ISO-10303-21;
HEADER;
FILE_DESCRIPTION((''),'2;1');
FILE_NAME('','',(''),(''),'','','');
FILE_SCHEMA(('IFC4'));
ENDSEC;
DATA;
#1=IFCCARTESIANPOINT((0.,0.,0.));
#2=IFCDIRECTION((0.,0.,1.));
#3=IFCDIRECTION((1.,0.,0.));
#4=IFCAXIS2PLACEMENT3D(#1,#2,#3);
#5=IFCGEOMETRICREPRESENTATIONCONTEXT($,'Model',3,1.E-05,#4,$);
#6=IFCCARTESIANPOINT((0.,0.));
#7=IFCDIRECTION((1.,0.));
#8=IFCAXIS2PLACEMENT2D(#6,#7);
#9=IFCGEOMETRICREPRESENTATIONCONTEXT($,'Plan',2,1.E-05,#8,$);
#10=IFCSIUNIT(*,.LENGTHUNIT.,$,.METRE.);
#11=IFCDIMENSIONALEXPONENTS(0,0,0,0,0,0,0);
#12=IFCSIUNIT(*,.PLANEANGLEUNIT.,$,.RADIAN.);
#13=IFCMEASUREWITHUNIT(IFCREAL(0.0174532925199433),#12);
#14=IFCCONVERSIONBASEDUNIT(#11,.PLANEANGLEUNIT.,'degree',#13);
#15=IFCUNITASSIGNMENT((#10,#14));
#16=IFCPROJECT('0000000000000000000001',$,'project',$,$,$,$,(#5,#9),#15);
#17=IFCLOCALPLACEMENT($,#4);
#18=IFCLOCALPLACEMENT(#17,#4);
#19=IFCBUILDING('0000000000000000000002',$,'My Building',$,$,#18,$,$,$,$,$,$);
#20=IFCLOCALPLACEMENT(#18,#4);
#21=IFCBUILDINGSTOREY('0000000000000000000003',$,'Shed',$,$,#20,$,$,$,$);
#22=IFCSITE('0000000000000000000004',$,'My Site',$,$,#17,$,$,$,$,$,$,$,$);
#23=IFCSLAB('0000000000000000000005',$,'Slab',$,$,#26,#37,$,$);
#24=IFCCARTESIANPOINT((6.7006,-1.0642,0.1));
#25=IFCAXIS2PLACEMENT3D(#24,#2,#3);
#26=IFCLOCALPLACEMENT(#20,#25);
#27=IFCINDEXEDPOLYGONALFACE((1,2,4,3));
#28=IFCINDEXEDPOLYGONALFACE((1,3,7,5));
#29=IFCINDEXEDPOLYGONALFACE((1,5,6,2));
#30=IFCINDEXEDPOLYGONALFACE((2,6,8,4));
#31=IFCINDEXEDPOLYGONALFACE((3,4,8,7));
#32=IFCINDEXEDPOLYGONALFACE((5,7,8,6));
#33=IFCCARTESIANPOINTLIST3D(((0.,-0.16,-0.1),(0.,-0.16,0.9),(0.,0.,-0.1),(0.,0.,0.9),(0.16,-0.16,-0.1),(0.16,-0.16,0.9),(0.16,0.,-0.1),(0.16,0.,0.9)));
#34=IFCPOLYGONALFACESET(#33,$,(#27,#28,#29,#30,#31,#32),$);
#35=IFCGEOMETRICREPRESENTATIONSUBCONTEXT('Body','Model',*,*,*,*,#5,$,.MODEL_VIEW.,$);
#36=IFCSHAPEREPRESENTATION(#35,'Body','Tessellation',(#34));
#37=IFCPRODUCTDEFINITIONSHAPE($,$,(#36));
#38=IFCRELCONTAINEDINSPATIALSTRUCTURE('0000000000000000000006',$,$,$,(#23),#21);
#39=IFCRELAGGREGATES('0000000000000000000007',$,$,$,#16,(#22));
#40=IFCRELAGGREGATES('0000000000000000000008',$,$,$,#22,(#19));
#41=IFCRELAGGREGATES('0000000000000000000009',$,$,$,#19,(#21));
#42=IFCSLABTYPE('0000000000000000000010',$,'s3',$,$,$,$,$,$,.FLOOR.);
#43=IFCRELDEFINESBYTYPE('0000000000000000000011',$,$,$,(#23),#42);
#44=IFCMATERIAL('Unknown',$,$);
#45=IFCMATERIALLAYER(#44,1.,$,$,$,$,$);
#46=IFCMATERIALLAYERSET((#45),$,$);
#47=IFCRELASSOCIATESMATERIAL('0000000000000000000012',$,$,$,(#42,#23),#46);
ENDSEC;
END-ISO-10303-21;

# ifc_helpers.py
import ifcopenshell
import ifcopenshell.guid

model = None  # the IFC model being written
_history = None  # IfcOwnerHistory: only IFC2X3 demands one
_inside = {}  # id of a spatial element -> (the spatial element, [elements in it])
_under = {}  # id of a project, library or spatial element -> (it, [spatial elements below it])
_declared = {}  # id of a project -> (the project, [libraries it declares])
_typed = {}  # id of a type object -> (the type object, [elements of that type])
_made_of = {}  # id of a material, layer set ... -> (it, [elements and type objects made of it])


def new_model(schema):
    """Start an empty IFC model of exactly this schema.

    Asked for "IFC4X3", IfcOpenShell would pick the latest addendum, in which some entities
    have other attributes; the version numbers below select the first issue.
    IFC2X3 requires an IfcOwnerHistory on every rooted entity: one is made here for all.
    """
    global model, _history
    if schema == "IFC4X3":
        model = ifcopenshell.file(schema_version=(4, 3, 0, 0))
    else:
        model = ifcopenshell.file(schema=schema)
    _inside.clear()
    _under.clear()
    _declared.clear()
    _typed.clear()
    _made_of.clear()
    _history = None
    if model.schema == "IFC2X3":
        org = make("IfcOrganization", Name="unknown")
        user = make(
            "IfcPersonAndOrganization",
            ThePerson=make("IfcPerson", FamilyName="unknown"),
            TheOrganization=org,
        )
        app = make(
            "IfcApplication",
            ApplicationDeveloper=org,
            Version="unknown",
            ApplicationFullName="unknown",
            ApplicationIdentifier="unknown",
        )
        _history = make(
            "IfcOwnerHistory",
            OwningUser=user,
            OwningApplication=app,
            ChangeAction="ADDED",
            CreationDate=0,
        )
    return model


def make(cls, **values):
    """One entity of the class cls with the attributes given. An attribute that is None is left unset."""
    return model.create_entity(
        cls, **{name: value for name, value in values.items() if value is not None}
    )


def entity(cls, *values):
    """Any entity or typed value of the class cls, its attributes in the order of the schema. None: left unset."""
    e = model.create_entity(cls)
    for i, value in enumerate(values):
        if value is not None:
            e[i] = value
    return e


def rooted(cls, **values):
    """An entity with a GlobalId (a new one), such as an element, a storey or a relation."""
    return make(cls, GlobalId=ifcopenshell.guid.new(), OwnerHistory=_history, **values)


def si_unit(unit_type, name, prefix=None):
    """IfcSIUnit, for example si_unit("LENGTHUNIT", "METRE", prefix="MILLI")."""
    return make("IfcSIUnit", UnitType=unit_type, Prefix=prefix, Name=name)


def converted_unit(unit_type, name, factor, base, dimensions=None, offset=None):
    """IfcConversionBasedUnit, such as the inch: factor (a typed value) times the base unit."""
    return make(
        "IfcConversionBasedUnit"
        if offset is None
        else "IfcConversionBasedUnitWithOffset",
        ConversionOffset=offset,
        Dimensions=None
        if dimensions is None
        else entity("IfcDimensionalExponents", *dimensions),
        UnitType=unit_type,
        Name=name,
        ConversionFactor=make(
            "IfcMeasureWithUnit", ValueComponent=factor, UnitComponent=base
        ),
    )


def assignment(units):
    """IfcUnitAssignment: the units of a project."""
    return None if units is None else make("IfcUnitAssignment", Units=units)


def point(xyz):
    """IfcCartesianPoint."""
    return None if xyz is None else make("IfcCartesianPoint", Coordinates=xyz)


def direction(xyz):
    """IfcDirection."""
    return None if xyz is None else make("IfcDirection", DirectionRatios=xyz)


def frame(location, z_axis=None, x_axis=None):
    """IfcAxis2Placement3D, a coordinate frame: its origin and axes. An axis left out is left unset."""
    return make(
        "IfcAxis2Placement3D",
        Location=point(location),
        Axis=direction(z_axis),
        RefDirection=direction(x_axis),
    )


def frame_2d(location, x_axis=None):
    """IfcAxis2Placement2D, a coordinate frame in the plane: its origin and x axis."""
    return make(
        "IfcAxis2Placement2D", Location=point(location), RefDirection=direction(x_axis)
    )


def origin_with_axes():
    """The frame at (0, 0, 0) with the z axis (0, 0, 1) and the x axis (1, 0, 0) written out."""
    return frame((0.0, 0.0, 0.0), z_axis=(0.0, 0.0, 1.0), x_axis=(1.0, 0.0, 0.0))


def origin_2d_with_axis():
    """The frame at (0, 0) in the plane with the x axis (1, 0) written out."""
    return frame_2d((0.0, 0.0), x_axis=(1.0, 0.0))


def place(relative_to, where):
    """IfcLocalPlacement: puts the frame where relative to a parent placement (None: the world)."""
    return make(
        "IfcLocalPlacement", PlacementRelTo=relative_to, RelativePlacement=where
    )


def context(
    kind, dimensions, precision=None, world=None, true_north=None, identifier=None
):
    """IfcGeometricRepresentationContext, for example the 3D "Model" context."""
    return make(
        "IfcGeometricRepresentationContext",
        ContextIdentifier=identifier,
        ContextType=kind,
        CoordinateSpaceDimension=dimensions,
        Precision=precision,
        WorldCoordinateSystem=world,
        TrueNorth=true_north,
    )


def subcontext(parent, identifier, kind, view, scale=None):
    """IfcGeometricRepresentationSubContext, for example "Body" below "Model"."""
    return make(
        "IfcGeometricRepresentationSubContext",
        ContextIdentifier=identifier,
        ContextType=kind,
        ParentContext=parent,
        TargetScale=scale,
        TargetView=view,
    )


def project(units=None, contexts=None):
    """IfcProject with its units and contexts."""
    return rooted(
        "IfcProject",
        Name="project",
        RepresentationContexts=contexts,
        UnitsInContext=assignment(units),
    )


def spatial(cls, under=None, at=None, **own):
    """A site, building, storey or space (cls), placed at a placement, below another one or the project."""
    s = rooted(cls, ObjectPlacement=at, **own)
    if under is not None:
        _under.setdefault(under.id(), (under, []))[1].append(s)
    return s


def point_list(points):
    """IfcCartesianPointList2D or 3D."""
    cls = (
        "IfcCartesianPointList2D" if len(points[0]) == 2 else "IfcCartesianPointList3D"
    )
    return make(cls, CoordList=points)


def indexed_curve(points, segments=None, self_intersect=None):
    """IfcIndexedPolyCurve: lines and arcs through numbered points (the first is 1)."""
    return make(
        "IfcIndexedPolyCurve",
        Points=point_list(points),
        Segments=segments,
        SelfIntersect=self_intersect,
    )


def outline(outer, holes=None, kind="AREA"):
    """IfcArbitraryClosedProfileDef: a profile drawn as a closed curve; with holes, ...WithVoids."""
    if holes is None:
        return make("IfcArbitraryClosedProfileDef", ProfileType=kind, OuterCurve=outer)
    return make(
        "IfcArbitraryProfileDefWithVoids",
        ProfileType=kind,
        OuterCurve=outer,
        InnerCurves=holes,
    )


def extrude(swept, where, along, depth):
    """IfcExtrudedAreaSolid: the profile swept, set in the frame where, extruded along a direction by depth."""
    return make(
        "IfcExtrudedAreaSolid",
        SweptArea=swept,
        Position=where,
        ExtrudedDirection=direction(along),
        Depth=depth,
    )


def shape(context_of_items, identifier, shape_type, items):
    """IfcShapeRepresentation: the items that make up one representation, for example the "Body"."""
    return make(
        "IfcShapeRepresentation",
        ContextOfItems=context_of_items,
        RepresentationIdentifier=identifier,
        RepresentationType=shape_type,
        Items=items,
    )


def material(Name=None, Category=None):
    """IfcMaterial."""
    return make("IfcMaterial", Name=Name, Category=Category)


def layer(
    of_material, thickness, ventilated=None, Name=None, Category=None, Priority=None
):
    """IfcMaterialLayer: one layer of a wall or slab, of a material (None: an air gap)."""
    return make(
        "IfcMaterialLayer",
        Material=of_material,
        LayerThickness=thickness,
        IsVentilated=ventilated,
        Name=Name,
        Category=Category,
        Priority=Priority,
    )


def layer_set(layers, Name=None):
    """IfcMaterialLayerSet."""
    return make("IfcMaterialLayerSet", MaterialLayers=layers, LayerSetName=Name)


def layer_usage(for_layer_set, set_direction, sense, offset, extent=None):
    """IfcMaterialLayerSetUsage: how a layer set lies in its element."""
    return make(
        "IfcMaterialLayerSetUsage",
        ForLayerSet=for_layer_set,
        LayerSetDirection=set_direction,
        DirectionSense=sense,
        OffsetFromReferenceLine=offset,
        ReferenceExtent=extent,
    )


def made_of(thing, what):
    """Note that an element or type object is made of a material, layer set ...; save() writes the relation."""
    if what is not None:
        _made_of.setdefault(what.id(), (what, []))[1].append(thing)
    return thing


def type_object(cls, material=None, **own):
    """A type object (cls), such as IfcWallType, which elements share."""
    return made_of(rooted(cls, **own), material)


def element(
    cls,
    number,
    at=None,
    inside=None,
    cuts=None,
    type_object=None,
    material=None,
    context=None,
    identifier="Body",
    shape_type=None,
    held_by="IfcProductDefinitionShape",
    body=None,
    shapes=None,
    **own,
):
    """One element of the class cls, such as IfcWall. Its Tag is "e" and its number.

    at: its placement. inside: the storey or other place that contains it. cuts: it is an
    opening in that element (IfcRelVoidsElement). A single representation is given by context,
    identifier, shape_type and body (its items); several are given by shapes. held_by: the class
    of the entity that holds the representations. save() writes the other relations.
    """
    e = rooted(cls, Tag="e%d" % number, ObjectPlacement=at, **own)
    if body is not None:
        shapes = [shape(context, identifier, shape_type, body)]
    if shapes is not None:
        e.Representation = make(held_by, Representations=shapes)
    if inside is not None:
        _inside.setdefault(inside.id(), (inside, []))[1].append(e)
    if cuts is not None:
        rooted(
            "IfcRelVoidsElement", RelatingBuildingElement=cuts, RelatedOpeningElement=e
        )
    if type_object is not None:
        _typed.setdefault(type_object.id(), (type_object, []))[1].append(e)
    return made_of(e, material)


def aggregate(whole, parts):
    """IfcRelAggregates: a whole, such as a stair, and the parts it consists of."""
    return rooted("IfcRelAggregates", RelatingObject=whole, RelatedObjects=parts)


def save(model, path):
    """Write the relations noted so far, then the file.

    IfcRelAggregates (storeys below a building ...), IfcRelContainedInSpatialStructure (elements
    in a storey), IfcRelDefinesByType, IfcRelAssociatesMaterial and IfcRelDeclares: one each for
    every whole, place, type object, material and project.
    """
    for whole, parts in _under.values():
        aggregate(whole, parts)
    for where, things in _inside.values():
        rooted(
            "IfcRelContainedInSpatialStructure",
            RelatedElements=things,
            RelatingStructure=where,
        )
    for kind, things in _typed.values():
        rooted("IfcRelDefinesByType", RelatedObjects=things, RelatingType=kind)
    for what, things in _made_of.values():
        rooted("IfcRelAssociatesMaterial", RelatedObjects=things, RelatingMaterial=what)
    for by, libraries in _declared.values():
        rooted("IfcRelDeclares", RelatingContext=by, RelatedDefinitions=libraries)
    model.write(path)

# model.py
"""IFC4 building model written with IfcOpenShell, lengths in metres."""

from ifc_helpers import new_model, entity, si_unit, converted_unit, frame, origin_with_axes, origin_2d_with_axis, place, context, subcontext, project, spatial, indexed_curve, outline, extrude, material, layer, layer_set, layer_usage, type_object, element, save


model = new_model("IFC4")

# Units and contexts
model_context = context("Model", 3, precision=1e-05, world=origin_with_axes())
plan_context = context("Plan", 2, precision=1e-05, world=origin_2d_with_axis())
body_context_1 = subcontext(model_context, "Body", "Model", "MODEL_VIEW")
ifc_project = project(units=[si_unit("LENGTHUNIT", "METRE"), converted_unit("PLANEANGLEUNIT", "degree", entity("IfcReal", 0.0174532925199433), si_unit("PLANEANGLEUNIT", "RADIAN"), dimensions=[0, 0, 0, 0, 0, 0, 0])], contexts=[model_context, plan_context])

# Site, building, storey
site_placement = place(None, origin_with_axes())
site = spatial("IfcSite", under=ifc_project, at=site_placement, Name="My Site")
building_placement = place(site_placement, origin_with_axes())
building = spatial("IfcBuilding", under=site, at=building_placement, Name="My Building")
storey_placement = place(building_placement, origin_with_axes())
storey = spatial("IfcBuildingStorey", under=building, at=storey_placement, Name="Shed")

# Shared definitions
ifc_material = material(Name="Unknown")

# Slab
ifc_layer_1 = layer(ifc_material, 1.0)
ifc_layer_set_1 = layer_set([ifc_layer_1])
ifc_layer_usage_1 = layer_usage(ifc_layer_set_1, "AXIS3", "POSITIVE", -0.1)
slab_type_1 = type_object("IfcSlabType", Name="s3", PredefinedType="FLOOR", material=ifc_layer_set_1)
slab_1_placement = place(storey_placement, frame((6.7006, -1.0642, 0.1), z_axis=(0.0, 0.0, 1.0), x_axis=(1.0, 0.0, 0.0)))
element("IfcSlab", 1, at=slab_1_placement, inside=storey, type_object=slab_type_1, material=ifc_layer_usage_1, Name="Slab", context=body_context_1, shape_type="SweptSolid", body=[
    extrude(outline(indexed_curve([(0.0, 0.0), (0.0, -0.16), (0.16, -0.16), (0.16, 0.0), (0.0, 0.0)])), frame((0.0, 0.0, -0.1), z_axis=(0.0, 0.0, 1.0), x_axis=(1.0, 0.0, 0.0)), (0.0, 0.0, 1.0), 1.0),
])

save(model, "model.ifc")
